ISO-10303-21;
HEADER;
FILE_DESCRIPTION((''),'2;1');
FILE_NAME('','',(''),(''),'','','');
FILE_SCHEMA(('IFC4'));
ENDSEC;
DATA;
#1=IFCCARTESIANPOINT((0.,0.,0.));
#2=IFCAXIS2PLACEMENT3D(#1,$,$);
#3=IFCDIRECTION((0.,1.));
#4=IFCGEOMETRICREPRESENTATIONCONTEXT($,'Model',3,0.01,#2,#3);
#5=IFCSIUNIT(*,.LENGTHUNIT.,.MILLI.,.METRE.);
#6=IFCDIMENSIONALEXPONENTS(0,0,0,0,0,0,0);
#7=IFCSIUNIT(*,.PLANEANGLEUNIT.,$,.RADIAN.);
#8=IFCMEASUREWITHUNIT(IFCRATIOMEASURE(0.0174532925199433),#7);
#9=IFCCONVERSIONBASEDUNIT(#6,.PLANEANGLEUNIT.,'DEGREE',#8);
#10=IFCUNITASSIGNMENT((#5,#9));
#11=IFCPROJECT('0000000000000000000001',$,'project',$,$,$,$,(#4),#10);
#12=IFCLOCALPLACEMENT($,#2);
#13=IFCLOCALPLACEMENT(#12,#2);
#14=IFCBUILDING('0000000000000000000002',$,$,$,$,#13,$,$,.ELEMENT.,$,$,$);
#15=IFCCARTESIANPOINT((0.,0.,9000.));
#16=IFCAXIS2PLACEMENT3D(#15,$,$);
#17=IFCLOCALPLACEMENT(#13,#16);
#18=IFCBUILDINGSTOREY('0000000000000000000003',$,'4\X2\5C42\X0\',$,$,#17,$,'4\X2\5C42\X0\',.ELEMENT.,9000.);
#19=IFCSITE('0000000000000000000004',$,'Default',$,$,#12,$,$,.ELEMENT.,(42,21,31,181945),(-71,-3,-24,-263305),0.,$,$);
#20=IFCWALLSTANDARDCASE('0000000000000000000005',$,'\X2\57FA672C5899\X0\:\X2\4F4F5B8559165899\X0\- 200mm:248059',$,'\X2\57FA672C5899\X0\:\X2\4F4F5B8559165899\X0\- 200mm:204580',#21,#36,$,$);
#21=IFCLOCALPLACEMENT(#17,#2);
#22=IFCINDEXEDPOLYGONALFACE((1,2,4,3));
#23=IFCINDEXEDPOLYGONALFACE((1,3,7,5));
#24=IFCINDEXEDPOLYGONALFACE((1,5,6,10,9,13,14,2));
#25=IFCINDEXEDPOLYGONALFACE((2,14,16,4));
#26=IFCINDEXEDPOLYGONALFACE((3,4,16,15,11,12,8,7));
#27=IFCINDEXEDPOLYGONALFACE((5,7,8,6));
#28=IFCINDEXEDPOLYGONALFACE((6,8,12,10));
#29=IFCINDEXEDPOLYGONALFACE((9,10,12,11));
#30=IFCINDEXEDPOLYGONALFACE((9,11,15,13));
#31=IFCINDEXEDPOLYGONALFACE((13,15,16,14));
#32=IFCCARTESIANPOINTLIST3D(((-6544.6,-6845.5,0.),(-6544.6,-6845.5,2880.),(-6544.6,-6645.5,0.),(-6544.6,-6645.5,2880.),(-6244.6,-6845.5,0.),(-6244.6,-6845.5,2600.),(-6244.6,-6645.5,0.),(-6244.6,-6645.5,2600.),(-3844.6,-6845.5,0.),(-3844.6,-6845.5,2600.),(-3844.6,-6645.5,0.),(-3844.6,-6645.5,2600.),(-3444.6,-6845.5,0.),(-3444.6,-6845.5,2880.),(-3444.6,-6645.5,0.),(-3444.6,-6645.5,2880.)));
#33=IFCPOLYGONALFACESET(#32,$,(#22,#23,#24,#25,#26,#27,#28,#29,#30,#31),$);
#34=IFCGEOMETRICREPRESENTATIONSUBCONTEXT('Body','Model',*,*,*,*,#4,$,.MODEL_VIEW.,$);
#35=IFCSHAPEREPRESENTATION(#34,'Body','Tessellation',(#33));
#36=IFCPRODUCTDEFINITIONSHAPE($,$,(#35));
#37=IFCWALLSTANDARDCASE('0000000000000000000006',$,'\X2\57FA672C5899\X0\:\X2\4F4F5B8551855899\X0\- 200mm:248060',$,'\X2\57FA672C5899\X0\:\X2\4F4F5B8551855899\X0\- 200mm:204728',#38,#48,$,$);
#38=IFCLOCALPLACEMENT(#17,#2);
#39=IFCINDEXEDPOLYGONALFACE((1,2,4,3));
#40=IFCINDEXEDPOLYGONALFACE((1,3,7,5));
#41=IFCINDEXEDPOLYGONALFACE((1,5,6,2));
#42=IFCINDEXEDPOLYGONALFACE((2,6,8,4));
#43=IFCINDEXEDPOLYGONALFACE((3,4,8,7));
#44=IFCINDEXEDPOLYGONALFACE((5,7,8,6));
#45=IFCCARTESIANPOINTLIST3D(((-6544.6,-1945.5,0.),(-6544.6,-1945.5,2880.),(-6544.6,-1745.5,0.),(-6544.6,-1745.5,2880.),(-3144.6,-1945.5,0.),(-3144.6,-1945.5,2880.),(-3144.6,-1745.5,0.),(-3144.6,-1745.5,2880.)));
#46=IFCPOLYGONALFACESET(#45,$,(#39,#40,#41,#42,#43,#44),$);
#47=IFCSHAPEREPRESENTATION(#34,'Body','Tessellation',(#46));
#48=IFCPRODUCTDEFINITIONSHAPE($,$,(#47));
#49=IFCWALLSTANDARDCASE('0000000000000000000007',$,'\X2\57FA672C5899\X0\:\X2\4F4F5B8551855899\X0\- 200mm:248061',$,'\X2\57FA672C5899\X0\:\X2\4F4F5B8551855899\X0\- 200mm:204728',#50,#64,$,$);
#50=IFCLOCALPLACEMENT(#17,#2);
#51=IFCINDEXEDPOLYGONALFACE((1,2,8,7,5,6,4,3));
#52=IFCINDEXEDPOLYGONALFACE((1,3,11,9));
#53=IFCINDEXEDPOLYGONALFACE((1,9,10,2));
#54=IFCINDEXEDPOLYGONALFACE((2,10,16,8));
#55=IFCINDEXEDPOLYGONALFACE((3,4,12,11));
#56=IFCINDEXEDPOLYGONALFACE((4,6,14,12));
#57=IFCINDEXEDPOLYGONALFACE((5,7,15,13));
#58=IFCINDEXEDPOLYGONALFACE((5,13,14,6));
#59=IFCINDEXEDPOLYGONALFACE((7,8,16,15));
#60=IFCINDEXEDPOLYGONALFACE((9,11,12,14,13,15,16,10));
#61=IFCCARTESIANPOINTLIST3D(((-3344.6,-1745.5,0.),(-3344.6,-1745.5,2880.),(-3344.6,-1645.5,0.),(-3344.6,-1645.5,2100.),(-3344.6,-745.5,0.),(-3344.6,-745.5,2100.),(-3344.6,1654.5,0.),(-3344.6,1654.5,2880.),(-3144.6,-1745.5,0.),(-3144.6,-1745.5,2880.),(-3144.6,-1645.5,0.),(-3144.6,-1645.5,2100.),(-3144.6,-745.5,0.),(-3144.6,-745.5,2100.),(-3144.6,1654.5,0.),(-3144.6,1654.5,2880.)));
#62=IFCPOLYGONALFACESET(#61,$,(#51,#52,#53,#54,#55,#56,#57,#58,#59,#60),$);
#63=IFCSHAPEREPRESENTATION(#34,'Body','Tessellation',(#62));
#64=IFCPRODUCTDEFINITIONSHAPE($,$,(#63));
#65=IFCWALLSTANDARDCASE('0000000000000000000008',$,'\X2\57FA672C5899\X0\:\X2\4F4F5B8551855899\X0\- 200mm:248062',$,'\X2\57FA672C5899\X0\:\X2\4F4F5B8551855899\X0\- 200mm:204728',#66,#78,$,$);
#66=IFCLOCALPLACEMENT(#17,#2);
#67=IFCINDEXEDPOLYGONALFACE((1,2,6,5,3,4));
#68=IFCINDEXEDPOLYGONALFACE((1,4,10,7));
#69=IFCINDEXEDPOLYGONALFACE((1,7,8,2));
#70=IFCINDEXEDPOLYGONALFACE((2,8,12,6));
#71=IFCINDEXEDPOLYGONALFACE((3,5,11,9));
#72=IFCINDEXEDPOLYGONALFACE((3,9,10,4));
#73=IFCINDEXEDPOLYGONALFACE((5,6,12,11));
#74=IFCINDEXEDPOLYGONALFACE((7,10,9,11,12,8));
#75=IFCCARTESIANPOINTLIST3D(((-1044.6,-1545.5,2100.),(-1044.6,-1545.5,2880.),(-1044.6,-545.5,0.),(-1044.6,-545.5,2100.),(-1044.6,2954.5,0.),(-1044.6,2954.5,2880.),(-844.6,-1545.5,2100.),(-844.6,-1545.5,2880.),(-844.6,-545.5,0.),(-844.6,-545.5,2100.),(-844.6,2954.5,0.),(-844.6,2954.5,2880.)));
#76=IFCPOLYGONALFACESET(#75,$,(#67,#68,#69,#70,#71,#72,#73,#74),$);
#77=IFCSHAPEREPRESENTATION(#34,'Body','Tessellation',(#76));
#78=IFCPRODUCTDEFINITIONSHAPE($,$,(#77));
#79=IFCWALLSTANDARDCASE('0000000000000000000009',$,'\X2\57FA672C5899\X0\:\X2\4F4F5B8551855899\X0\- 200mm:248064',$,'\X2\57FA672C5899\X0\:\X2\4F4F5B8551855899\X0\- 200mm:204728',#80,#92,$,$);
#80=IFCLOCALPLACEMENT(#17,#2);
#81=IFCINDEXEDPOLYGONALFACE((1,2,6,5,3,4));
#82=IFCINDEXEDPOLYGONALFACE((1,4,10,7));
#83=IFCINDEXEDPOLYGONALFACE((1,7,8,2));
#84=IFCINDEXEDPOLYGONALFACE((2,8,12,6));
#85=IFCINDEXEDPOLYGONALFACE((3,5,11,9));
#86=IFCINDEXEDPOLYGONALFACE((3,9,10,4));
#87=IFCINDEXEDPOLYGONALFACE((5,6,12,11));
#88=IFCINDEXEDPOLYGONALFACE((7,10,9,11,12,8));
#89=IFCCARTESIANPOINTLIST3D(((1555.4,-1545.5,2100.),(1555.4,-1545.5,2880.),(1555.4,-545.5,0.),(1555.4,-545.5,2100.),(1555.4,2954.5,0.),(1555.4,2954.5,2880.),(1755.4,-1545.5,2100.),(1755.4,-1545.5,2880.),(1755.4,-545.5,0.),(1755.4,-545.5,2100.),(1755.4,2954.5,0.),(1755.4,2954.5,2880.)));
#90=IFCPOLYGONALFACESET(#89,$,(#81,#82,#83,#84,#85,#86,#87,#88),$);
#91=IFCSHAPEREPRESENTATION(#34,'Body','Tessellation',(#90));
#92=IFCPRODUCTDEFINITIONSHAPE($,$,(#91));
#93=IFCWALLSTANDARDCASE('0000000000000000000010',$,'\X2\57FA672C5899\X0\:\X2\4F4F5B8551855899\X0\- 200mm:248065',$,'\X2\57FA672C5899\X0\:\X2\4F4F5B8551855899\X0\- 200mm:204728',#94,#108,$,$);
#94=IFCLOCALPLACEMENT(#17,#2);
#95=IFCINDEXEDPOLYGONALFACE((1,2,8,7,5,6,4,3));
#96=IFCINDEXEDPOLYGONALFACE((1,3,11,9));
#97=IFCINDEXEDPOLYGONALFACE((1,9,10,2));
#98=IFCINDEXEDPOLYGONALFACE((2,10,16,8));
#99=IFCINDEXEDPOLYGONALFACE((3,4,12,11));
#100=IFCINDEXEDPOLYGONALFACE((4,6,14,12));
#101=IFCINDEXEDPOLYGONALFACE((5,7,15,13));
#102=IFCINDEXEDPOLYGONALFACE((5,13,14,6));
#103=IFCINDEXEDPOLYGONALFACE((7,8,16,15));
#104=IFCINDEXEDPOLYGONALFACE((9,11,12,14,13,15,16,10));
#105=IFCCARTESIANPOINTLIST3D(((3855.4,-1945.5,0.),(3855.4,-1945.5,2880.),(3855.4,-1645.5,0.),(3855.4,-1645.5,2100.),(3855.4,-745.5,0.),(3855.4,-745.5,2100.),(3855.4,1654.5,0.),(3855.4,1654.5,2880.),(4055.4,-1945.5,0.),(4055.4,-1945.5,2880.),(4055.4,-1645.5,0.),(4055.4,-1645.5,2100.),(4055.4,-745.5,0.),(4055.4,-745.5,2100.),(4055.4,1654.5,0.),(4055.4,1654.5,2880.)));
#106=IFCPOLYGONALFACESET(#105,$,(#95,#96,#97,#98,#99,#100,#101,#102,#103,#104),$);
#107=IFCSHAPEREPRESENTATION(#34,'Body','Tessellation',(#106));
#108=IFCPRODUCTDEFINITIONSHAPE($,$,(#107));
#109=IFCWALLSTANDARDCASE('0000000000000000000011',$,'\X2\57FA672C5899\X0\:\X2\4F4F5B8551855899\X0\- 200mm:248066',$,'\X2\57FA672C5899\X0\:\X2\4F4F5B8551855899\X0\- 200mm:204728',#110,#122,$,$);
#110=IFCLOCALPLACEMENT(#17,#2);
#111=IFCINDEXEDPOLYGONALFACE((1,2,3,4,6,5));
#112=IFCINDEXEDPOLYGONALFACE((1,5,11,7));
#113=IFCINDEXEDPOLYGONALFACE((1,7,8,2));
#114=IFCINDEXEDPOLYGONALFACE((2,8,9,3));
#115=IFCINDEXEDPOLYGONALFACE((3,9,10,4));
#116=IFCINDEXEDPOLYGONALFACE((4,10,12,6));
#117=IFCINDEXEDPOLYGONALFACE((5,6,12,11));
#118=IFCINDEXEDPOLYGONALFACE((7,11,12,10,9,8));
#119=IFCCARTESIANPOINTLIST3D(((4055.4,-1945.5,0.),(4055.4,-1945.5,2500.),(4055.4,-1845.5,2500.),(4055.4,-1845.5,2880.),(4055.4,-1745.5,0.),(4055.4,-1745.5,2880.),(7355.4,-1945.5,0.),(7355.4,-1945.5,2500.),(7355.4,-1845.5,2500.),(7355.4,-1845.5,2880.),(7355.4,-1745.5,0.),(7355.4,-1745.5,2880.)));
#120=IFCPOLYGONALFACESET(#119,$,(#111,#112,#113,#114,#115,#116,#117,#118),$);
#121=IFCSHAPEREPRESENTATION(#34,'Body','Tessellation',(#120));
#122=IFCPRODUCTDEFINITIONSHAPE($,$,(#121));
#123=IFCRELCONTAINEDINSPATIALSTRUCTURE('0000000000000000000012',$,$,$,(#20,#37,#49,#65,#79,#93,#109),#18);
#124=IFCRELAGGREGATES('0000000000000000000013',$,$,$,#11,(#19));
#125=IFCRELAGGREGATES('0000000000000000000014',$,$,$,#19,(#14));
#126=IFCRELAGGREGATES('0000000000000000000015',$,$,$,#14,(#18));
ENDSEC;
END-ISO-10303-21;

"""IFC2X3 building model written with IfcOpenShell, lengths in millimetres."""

from ifc_helpers import new_model, entity, si_unit, converted_unit, direction, frame, frame_2d, origin, place, context, subcontext, project, spatial, polyline, rectangle, extrude, clip, bounded_halfspace, element, save


model = new_model("IFC2X3")

# Units and contexts
model_context = context("Model", 3, precision=0.01, world=origin(), true_north=direction((0.0, 1.0)))
body_context = subcontext(model_context, "Body", "Model", "MODEL_VIEW")
ifc_project = project(units=[si_unit("LENGTHUNIT", "METRE", prefix="MILLI"), converted_unit("PLANEANGLEUNIT", "DEGREE", entity("IfcRatioMeasure", 0.0174532925199433), si_unit("PLANEANGLEUNIT", "RADIAN"), dimensions=[0, 0, 0, 0, 0, 0, 0])], contexts=[model_context])

# Site, building, storey
site_placement = place(None, origin())
site = spatial("IfcSite", under=ifc_project, at=site_placement, Name="Default", CompositionType="ELEMENT", RefLatitude=(42, 21, 31, 181945), RefLongitude=(-71, -3, -24, -263305), RefElevation=0.0)
building_placement = place(site_placement, origin())
building = spatial("IfcBuilding", under=site, at=building_placement, CompositionType="ELEMENT")
storey_placement = place(building_placement, frame((0.0, 0.0, 9000.0)))
storey = spatial("IfcBuildingStorey", under=building, at=storey_placement, Name="4层", LongName="4层", CompositionType="ELEMENT", Elevation=9000.0)

# Wall, opening
wall_1_placement = place(storey_placement, frame((-3444.6, -6745.5, 0.0), z_axis=(0.0, 0.0, 1.0), x_axis=(-1.0, 0.0, 0.0)))
wall_1 = element("IfcWallStandardCase", 1, at=wall_1_placement, inside=storey, Name="基本墙:住宅外墙- 200mm:248059", ObjectType="基本墙:住宅外墙- 200mm:204580", context=body_context, shape_type="Clipping", body=[
    clip(clip(clip(extrude(rectangle(XDim=3100.0, YDim=200.0, at=frame_2d((1550.0, 0.0), x_axis=(-1.0, 0.0))), origin(), (0.0, 0.0, 1.0), 2880.0), bounded_halfspace(frame((0.0, 100.0, 2880.0), z_axis=(0.0, 0.0, -1.0), x_axis=(0.0, 1.0, 0.0)), True, frame((0.0, 100.0, 2880.0)), polyline([(0.0, 0.0), (0.0, -200.0), (3100.0, -200.0), (3100.0, 0.0), (0.0, 0.0)]))), bounded_halfspace(frame((0.0, -100.0, 0.0), z_axis=(1.0, 0.0, 0.0), x_axis=(0.0, 0.0, -1.0)), True, frame((0.0, -100.0, 0.0), z_axis=(1.0, 0.0, 0.0), x_axis=(0.0, 0.0, -1.0)), polyline([(0.0, 0.0), (0.0, 200.0), (-2880.0, 200.0), (-2880.0, 0.0), (0.0, 0.0)]))), bounded_halfspace(frame((3100.0, -100.0, 2880.0), z_axis=(-1.0, 0.0, 0.0), x_axis=(0.0, 0.0, -1.0)), True, frame((3100.0, -100.0, 2880.0), z_axis=(-1.0, 0.0, 0.0), x_axis=(0.0, 0.0, -1.0)), polyline([(0.0, 0.0), (0.0, -200.0), (2880.0, -200.0), (2880.0, 0.0), (0.0, 0.0)]))),
])
opening_1_placement = place(wall_1_placement, frame((400.0, -100.0, 0.0)))
element("IfcOpeningElement", 2, at=opening_1_placement, cuts=wall_1, ObjectType="Opening", context=body_context, shape_type="SweptSolid", body=[
    extrude(rectangle(XDim=2600.0, YDim=2400.0, at=frame_2d((1300.0, 1200.0), x_axis=(1.0, 0.0))), frame((0.0, 0.0, 0.0), z_axis=(0.0, 1.0, 0.0), x_axis=(0.0, 0.0, 1.0)), (0.0, 0.0, 1.0), 200.0),
])

# Wall
wall_2_placement = place(storey_placement, frame((-6544.6, -1845.5, 0.0)))
element("IfcWallStandardCase", 3, at=wall_2_placement, inside=storey, Name="基本墙:住宅内墙- 200mm:248060", ObjectType="基本墙:住宅内墙- 200mm:204728", context=body_context, shape_type="Clipping", body=[
    clip(clip(extrude(rectangle(XDim=3400.0, YDim=200.0, at=frame_2d((1700.0, 0.0), x_axis=(-1.0, 0.0))), origin(), (0.0, 0.0, 1.0), 2880.0), bounded_halfspace(frame((3400.0, -100.0, 2880.0), z_axis=(0.0, 0.0, -1.0), x_axis=(0.0, -1.0, 0.0)), True, frame((3400.0, -100.0, 2880.0)), polyline([(0.0, 0.0), (0.0, 200.0), (-200.0, 200.0), (-3400.0, 200.0), (-3400.0, 0.0), (0.0, 0.0)]))), bounded_halfspace(frame((0.0, -100.0, 0.0), z_axis=(1.0, 0.0, 0.0), x_axis=(0.0, 0.0, -1.0)), True, frame((0.0, -100.0, 0.0), z_axis=(1.0, 0.0, 0.0), x_axis=(0.0, 0.0, -1.0)), polyline([(0.0, 0.0), (0.0, 200.0), (-2880.0, 200.0), (-2880.0, 0.0), (0.0, 0.0)]))),
])

# Walls, openings
wall_3_placement = place(storey_placement, frame((-3244.6, -1745.5, 0.0), z_axis=(0.0, 0.0, 1.0), x_axis=(0.0, 1.0, 0.0)))
wall_3 = element("IfcWallStandardCase", 4, at=wall_3_placement, inside=storey, Name="基本墙:住宅内墙- 200mm:248061", ObjectType="基本墙:住宅内墙- 200mm:204728", context=body_context, shape_type="Clipping", body=[
    clip(extrude(rectangle(XDim=3400.0, YDim=200.0, at=frame_2d((1700.0, 0.0), x_axis=(-1.0, 0.0))), origin(), (0.0, 0.0, 1.0), 2880.0), bounded_halfspace(frame((0.0, -100.0, 2880.0), z_axis=(0.0, 0.0, -1.0), x_axis=(-1.0, 0.0, 0.0)), True, frame((0.0, -100.0, 2880.0)), polyline([(0.0, 0.0), (1900.0, 0.0), (2100.0, 0.0), (3400.0, 0.0), (3400.0, 200.0), (0.0, 200.0), (0.0, 0.0)]))),
])
opening_2_placement = place(wall_3_placement, frame((100.0, -100.0, 0.0)))
element("IfcOpeningElement", 5, at=opening_2_placement, cuts=wall_3, ObjectType="Opening", context=body_context, shape_type="SweptSolid", body=[
    extrude(rectangle(XDim=2100.0, YDim=900.0, at=frame_2d((1050.0, 450.0), x_axis=(1.0, 0.0))), frame((0.0, 0.0, 0.0), z_axis=(0.0, 1.0, 0.0), x_axis=(0.0, 0.0, 1.0)), (0.0, 0.0, 1.0), 200.0),
])
wall_4_placement = place(storey_placement, frame((-944.6, 2954.5, 0.0), z_axis=(0.0, 0.0, 1.0), x_axis=(0.0, -1.0, 0.0)))
wall_4 = element("IfcWallStandardCase", 6, at=wall_4_placement, inside=storey, Name="基本墙:住宅内墙- 200mm:248062", ObjectType="基本墙:住宅内墙- 200mm:204728", context=body_context, shape_type="Clipping", body=[
    clip(clip(extrude(rectangle(XDim=4500.0, YDim=200.0, at=frame_2d((2250.0, 0.0), x_axis=(-1.0, 0.0))), origin(), (0.0, 0.0, 1.0), 2880.0), bounded_halfspace(frame((4500.0, -100.0, 2880.0), z_axis=(-1.0, 0.0, 0.0), x_axis=(0.0, 0.0, -1.0)), True, frame((4500.0, -100.0, 2880.0), z_axis=(-1.0, 0.0, 0.0), x_axis=(0.0, 0.0, -1.0)), polyline([(0.0, 0.0), (0.0, -200.0), (780.0, -200.0), (780.0, 0.0), (0.0, 0.0)]))), bounded_halfspace(frame((0.0, -100.0, 0.0), z_axis=(1.0, 0.0, 0.0), x_axis=(0.0, 0.0, -1.0)), True, frame((0.0, -100.0, 0.0), z_axis=(1.0, 0.0, 0.0), x_axis=(0.0, 0.0, -1.0)), polyline([(0.0, 0.0), (0.0, 200.0), (-2880.0, 200.0), (-2880.0, 0.0), (0.0, 0.0)]))),
])
opening_3_placement = place(wall_4_placement, frame((3500.0, -100.0, 0.0)))
element("IfcOpeningElement", 7, at=opening_3_placement, cuts=wall_4, ObjectType="Opening", context=body_context, shape_type="SweptSolid", body=[
    extrude(rectangle(XDim=2100.0, YDim=1000.0, at=frame_2d((1050.0, 500.0), x_axis=(1.0, 0.0))), frame((0.0, 0.0, 0.0), z_axis=(0.0, 1.0, 0.0), x_axis=(0.0, 0.0, 1.0)), (0.0, 0.0, 1.0), 200.0),
])
wall_5_placement = place(storey_placement, frame((1655.4, -1545.5, 0.0), z_axis=(0.0, 0.0, 1.0), x_axis=(0.0, 1.0, 0.0)))
wall_5 = element("IfcWallStandardCase", 8, at=wall_5_placement, inside=storey, Name="基本墙:住宅内墙- 200mm:248064", ObjectType="基本墙:住宅内墙- 200mm:204728", context=body_context, shape_type="Clipping", body=[
    clip(clip(extrude(rectangle(XDim=4500.0, YDim=200.0, at=frame_2d((2250.0, 0.0), x_axis=(-1.0, 0.0))), origin(), (0.0, 0.0, 1.0), 2880.0), bounded_halfspace(frame((0.0, -100.0, 2100.0), z_axis=(-1.0, 0.0, 0.0), x_axis=(0.0, 0.0, -1.0)), False, frame((0.0, -100.0, 2100.0), z_axis=(-1.0, 0.0, 0.0), x_axis=(0.0, 0.0, -1.0)), polyline([(0.0, 0.0), (-780.0, 0.0), (-780.0, -200.0), (0.0, -200.0), (0.0, 0.0)]))), bounded_halfspace(frame((4500.0, -100.0, 2880.0), z_axis=(1.0, 0.0, 0.0), x_axis=(0.0, 0.0, -1.0)), False, frame((4500.0, -100.0, 2880.0), z_axis=(1.0, 0.0, 0.0), x_axis=(0.0, 0.0, -1.0)), polyline([(0.0, 0.0), (2880.0, 0.0), (2880.0, 200.0), (0.0, 200.0), (0.0, 0.0)]))),
])
opening_4_placement = place(wall_5_placement, frame((0.0, -100.0, 0.0)))
element("IfcOpeningElement", 9, at=opening_4_placement, cuts=wall_5, ObjectType="Opening", context=body_context, shape_type="SweptSolid", body=[
    extrude(rectangle(XDim=2100.0, YDim=1000.0, at=frame_2d((1050.0, 500.0), x_axis=(1.0, 0.0))), frame((0.0, 0.0, 0.0), z_axis=(0.0, 1.0, 0.0), x_axis=(0.0, 0.0, 1.0)), (0.0, 0.0, 1.0), 200.0),
])
wall_6_placement = place(storey_placement, frame((3955.4, 1654.5, 0.0), z_axis=(0.0, 0.0, 1.0), x_axis=(0.0, -1.0, 0.0)))
wall_6 = element("IfcWallStandardCase", 10, at=wall_6_placement, inside=storey, Name="基本墙:住宅内墙- 200mm:248065", ObjectType="基本墙:住宅内墙- 200mm:204728", context=body_context, shape_type="Clipping", body=[
    clip(extrude(rectangle(XDim=3600.0, YDim=200.0, at=frame_2d((1800.0, 0.0), x_axis=(-1.0, 0.0))), origin(), (0.0, 0.0, 1.0), 2880.0), bounded_halfspace(frame((0.0, -100.0, 2880.0), z_axis=(0.0, 0.0, -1.0), x_axis=(1.0, 0.0, 0.0)), True, frame((0.0, -100.0, 2880.0)), polyline([(0.0, 0.0), (1300.0, 0.0), (1500.0, 0.0), (3600.0, 0.0), (3600.0, 200.0), (3500.0, 200.0), (3400.0, 200.0), (0.0, 200.0), (0.0, 0.0)]))),
])
opening_5_placement = place(wall_6_placement, frame((2400.0, -100.0, 0.0)))
element("IfcOpeningElement", 11, at=opening_5_placement, cuts=wall_6, ObjectType="Opening", context=body_context, shape_type="SweptSolid", body=[
    extrude(rectangle(XDim=2100.0, YDim=900.0, at=frame_2d((1050.0, 450.0), x_axis=(1.0, 0.0))), frame((0.0, 0.0, 0.0), z_axis=(0.0, 1.0, 0.0), x_axis=(0.0, 0.0, 1.0)), (0.0, 0.0, 1.0), 200.0),
])

# Wall
wall_7_placement = place(storey_placement, frame((4055.4, -1845.5, 0.0)))
element("IfcWallStandardCase", 12, at=wall_7_placement, inside=storey, Name="基本墙:住宅内墙- 200mm:248066", ObjectType="基本墙:住宅内墙- 200mm:204728", context=body_context, shape_type="Clipping", body=[
    clip(clip(clip(clip(extrude(rectangle(XDim=3300.0, YDim=200.0, at=frame_2d((1650.0, 0.0), x_axis=(-1.0, 0.0))), origin(), (0.0, 0.0, 1.0), 2880.0), bounded_halfspace(frame((3300.0, 100.0, 2880.0), z_axis=(0.0, 0.0, -1.0), x_axis=(0.0, -1.0, 0.0)), True, frame((3300.0, 100.0, 2880.0)), polyline([(0.0, 0.0), (-3300.0, 0.0), (-3300.0, -100.0), (0.0, -100.0), (0.0, 0.0)]))), bounded_halfspace(frame((3300.0, 100.0, 0.0), z_axis=(1.0, 0.0, 0.0), x_axis=(0.0, 0.0, -1.0)), False, frame((3300.0, 100.0, 0.0), z_axis=(1.0, 0.0, 0.0), x_axis=(0.0, 0.0, -1.0)), polyline([(0.0, 0.0), (-2880.0, 0.0), (-2880.0, -100.0), (-2500.0, -100.0), (-2500.0, -200.0), (0.0, -200.0), (0.0, 0.0)]))), bounded_halfspace(frame((3300.0, 0.0, 2500.0)), False, frame((3300.0, 0.0, 2500.0)), polyline([(0.0, 0.0), (-3300.0, 0.0), (-3300.0, -100.0), (0.0, -100.0), (0.0, 0.0)]))), bounded_halfspace(frame((0.0, 0.0, 2500.0), z_axis=(0.0, -1.0, 0.0), x_axis=(1.0, 0.0, 0.0)), False, frame((0.0, 0.0, 2500.0), z_axis=(0.0, -1.0, 0.0), x_axis=(1.0, 0.0, 0.0)), polyline([(0.0, 0.0), (3300.0, 0.0), (3300.0, 380.0), (0.0, 380.0), (0.0, 0.0)]))),
])

save(model, "model.ifc")
